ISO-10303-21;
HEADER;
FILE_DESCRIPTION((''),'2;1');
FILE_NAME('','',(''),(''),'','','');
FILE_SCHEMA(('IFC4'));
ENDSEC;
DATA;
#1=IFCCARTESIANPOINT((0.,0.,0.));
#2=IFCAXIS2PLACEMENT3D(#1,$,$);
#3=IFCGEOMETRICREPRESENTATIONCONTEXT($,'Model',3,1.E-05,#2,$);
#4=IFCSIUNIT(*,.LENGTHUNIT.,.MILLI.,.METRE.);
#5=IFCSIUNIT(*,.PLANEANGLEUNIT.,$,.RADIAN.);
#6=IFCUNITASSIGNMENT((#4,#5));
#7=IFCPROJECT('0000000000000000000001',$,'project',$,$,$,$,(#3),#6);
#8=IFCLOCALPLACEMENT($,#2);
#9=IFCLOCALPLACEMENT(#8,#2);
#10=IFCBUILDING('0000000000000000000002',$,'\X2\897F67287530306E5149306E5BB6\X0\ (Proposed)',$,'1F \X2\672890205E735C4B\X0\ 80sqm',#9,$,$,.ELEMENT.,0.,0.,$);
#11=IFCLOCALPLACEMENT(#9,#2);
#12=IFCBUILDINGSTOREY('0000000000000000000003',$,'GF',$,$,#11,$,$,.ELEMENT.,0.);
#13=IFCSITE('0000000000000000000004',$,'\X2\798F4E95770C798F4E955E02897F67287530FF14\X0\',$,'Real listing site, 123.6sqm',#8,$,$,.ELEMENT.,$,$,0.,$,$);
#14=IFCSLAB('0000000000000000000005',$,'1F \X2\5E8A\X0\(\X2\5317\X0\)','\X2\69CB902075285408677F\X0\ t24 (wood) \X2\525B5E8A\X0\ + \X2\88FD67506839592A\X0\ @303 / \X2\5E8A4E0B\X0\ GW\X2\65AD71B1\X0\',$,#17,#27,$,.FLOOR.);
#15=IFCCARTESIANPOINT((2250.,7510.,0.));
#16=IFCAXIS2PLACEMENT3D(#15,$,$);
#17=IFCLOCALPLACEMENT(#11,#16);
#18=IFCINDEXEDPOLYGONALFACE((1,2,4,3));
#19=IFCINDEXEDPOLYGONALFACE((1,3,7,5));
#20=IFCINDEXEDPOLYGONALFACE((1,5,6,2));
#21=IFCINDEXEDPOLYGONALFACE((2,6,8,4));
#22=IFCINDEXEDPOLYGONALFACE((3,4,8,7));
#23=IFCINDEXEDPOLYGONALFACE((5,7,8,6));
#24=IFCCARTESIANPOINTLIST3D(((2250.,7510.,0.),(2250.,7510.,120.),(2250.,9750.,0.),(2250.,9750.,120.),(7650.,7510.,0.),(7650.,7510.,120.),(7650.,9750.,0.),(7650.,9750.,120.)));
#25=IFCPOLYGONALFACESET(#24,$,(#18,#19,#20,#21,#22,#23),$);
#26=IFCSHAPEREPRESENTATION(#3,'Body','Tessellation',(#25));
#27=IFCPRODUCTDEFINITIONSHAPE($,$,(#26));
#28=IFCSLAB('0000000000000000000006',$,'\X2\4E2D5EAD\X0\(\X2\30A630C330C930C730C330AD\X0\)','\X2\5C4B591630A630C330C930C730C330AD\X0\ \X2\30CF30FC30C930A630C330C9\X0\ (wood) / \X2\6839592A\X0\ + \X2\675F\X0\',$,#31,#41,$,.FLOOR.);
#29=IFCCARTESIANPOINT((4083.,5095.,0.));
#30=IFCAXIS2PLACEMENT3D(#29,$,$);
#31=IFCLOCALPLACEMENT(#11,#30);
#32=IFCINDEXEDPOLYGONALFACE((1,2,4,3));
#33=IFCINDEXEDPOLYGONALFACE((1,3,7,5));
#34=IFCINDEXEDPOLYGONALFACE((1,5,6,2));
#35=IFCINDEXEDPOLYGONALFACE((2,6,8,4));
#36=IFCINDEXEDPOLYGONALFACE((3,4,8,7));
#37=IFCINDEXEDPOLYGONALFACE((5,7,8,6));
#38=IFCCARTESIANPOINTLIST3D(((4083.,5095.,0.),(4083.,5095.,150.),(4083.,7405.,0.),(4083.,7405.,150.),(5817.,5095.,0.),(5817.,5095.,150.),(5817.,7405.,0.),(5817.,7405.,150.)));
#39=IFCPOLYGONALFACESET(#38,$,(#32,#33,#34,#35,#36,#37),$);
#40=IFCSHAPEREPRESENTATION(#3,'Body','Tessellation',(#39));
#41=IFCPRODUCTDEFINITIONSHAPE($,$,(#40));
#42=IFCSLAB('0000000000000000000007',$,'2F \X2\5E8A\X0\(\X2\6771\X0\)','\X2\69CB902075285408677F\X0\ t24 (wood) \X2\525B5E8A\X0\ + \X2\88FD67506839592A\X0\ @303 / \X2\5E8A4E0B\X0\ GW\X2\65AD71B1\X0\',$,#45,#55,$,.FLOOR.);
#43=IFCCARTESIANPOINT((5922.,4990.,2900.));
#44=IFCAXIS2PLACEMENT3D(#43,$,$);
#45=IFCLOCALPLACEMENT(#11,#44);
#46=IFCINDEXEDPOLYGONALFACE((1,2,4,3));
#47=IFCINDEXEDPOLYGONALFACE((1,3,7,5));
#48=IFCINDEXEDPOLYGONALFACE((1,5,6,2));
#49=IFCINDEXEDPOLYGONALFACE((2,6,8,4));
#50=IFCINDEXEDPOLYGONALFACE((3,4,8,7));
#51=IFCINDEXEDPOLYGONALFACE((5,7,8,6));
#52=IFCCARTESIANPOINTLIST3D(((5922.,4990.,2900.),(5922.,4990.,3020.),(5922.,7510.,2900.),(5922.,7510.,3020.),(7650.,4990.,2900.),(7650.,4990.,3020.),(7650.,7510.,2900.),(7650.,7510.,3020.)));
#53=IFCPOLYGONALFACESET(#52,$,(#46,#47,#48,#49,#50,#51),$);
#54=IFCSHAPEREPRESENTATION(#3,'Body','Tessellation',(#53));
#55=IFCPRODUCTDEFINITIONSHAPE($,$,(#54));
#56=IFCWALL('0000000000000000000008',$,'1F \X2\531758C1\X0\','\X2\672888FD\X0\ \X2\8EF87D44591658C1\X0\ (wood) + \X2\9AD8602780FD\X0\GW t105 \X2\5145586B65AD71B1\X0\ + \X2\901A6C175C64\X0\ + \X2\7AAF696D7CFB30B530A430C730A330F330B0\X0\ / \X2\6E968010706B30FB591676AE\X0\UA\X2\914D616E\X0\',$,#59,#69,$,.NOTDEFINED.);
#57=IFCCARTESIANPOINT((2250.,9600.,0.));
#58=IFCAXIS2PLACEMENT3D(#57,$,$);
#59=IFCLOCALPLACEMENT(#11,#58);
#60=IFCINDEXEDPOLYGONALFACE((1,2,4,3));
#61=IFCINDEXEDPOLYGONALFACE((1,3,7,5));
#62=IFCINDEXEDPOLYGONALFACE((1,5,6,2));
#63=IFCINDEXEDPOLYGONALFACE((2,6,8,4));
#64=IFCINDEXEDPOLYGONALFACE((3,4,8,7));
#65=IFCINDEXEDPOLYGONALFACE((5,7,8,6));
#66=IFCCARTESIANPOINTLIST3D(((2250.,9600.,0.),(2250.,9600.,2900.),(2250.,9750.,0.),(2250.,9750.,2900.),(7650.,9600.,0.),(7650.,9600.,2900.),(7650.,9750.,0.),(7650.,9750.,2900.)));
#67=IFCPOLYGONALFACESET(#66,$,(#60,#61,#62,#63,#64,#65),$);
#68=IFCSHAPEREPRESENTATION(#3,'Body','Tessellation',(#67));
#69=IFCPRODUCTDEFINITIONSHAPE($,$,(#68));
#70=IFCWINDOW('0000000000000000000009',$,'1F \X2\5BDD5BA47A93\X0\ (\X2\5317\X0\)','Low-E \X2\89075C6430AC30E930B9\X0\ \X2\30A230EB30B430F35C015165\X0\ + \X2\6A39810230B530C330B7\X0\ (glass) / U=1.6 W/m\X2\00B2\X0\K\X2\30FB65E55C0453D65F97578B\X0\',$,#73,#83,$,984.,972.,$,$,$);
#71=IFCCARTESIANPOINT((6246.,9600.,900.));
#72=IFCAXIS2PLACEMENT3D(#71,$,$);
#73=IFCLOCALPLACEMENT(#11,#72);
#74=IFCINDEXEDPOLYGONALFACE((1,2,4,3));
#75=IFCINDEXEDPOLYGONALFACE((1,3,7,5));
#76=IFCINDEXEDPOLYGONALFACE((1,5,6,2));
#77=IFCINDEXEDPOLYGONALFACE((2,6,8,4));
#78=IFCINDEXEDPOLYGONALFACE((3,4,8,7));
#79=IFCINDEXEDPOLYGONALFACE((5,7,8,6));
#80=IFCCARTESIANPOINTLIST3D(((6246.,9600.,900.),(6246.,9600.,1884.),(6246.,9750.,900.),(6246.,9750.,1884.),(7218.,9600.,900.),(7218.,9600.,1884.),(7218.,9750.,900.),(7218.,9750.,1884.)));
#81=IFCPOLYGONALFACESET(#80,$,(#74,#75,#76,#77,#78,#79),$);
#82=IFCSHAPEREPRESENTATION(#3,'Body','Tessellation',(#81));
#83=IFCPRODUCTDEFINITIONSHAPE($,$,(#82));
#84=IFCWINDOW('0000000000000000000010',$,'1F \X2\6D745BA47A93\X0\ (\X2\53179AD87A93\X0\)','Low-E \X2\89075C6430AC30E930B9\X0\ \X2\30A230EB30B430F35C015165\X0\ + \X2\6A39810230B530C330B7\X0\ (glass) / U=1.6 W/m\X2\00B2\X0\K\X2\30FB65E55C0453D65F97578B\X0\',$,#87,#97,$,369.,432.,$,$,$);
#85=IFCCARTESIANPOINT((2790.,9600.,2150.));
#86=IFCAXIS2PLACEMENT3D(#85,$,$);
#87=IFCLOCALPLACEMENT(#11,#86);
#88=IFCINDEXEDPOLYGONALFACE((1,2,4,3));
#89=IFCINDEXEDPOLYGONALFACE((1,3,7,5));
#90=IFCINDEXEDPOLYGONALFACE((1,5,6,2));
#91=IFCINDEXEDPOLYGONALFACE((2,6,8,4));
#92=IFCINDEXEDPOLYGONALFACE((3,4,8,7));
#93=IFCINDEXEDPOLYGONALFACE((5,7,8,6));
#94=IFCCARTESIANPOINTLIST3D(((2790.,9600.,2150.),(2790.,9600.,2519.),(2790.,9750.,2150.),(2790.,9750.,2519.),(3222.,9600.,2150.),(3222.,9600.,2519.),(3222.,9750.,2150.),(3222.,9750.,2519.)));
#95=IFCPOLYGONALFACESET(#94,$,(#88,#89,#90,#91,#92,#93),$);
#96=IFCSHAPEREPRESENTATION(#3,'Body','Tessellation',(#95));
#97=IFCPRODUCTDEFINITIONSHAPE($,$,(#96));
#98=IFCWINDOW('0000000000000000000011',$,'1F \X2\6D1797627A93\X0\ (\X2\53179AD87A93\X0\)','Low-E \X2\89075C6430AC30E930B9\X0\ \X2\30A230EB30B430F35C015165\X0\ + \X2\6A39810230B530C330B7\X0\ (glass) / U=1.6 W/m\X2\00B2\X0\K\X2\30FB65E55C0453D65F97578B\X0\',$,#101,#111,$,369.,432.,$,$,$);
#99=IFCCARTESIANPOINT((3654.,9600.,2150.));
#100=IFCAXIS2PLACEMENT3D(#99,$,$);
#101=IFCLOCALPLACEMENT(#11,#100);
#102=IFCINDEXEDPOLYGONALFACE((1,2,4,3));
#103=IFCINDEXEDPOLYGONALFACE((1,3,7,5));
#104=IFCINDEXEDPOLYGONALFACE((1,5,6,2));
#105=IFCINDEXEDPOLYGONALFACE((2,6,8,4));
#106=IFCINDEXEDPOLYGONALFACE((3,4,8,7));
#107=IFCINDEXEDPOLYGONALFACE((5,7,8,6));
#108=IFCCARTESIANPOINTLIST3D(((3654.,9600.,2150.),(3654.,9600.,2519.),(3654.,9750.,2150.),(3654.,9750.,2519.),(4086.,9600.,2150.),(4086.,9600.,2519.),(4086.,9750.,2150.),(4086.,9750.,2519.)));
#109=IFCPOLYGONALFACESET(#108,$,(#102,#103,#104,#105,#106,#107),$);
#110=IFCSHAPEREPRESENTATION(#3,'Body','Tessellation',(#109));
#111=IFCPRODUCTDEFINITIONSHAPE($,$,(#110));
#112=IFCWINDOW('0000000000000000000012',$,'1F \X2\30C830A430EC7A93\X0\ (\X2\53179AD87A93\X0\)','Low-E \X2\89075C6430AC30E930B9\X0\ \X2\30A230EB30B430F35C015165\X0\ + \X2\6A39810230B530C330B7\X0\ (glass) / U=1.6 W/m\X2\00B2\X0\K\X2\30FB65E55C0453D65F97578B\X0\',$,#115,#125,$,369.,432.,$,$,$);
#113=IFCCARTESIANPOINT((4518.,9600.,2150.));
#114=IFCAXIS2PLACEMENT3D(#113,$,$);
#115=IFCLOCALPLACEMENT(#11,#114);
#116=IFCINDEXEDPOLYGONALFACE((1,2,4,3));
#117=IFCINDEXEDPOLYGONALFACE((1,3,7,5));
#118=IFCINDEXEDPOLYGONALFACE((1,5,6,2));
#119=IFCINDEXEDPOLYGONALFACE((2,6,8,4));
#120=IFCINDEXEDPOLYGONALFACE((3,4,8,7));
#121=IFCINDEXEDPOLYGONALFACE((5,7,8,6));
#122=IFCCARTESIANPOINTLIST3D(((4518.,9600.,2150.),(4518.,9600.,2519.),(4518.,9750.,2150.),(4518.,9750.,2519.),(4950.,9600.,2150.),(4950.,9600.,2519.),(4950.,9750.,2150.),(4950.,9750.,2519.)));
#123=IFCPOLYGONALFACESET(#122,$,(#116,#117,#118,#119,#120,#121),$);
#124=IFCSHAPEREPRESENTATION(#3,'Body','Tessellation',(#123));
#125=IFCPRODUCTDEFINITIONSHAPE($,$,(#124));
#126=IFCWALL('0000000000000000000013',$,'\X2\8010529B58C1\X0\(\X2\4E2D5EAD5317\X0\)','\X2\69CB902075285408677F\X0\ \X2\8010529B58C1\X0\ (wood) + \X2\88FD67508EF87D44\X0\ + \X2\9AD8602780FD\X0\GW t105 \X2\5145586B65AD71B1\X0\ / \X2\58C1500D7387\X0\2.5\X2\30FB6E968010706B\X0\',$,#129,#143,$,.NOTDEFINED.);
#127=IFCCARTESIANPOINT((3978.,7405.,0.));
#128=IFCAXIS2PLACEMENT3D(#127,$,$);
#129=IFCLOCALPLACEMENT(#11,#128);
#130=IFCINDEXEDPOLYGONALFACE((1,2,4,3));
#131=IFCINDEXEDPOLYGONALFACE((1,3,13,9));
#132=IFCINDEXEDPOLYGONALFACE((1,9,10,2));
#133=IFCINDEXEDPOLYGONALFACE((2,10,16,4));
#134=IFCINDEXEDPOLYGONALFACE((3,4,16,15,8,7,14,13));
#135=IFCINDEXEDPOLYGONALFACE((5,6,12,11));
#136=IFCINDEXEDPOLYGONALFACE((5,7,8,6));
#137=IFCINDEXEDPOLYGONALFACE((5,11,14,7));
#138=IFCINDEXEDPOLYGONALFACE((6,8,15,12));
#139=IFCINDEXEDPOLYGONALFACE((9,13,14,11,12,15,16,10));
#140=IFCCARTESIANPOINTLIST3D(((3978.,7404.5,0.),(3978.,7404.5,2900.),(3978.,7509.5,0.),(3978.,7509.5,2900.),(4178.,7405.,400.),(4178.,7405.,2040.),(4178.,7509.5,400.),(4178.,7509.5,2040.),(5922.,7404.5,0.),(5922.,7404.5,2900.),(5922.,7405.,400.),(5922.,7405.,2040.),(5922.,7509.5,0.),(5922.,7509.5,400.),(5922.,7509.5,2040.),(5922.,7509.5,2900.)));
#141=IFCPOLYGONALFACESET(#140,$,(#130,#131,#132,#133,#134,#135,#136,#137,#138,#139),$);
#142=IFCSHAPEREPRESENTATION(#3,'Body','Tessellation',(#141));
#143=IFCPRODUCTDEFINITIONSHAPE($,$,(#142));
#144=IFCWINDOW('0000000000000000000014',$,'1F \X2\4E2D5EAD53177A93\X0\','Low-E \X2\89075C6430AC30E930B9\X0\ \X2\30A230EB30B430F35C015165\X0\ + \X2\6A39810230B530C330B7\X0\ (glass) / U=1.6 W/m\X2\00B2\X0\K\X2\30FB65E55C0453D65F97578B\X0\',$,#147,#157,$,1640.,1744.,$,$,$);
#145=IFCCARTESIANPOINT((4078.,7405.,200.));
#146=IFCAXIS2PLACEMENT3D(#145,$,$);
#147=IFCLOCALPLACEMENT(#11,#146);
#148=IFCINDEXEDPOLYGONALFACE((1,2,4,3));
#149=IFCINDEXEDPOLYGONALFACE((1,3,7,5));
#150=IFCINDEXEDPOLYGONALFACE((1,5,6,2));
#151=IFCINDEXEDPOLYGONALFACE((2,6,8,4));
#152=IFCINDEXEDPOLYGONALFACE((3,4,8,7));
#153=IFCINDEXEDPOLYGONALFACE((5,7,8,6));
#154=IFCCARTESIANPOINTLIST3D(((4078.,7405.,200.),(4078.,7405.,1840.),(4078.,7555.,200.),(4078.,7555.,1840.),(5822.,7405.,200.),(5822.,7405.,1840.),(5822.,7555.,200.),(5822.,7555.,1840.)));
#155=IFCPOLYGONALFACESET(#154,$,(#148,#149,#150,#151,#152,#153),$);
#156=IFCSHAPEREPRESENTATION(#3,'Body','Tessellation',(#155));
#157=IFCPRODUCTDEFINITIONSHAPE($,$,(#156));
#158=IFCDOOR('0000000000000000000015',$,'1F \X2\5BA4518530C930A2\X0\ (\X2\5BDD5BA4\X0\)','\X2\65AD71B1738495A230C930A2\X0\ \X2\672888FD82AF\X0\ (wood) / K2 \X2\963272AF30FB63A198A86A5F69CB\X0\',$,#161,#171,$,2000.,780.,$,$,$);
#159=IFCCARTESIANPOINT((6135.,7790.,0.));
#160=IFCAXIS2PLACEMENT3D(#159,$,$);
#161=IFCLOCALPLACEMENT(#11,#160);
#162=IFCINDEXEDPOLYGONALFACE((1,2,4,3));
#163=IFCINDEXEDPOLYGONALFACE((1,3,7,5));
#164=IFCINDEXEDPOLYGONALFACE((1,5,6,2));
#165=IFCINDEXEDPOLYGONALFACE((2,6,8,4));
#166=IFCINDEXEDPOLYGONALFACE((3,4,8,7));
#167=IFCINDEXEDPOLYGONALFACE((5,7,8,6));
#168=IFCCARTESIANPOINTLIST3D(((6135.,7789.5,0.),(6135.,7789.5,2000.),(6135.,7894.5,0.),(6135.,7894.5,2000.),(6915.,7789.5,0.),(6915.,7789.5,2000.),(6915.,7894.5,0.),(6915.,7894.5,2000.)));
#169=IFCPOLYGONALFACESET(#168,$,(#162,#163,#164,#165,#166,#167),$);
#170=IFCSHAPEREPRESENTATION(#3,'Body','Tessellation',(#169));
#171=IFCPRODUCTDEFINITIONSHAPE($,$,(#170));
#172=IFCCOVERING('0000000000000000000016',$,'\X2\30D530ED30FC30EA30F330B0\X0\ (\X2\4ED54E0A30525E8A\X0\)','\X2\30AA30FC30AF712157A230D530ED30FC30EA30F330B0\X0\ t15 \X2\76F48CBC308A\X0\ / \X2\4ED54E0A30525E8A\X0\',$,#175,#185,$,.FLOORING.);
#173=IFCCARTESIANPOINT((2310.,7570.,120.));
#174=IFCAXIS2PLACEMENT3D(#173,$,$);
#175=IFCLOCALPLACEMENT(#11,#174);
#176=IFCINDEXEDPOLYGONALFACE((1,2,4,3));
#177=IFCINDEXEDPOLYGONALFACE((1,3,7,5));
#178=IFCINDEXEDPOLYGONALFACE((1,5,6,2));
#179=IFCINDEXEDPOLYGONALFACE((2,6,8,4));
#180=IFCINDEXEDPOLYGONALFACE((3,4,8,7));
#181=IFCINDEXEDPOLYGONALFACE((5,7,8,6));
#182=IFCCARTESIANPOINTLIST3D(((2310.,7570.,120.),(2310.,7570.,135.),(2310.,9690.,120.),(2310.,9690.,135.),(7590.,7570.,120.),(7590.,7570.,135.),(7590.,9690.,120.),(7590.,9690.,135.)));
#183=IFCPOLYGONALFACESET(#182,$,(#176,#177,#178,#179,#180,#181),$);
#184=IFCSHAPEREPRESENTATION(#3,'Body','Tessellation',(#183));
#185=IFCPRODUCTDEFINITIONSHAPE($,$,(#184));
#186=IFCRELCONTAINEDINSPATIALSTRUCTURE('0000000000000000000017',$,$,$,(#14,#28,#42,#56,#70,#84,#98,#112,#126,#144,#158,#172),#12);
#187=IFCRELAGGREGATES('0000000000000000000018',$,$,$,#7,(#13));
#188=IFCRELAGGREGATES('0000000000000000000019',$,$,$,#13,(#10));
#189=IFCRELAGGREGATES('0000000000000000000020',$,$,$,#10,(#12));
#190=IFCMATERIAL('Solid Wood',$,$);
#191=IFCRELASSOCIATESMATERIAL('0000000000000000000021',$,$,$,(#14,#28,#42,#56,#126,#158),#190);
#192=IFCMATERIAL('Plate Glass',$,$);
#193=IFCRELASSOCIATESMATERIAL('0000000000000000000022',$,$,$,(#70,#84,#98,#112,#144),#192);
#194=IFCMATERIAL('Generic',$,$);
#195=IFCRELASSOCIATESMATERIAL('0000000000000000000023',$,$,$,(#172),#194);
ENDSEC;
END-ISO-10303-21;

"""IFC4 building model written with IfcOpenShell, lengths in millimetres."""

from ifc_helpers import new_model, si_unit, frame, frame_2d, origin, place, context, project, spatial, rectangle, extrude, material, element, fill, save


model = new_model("IFC4")

# Units and contexts
model_context = context("Model", 3, precision=1e-05, world=origin())
ifc_project = project(units=[si_unit("LENGTHUNIT", "METRE", prefix="MILLI"), si_unit("PLANEANGLEUNIT", "RADIAN")], contexts=[model_context])

# Site, building, storey
site_placement = place(None, origin())
site = spatial("IfcSite", under=ifc_project, at=site_placement, Name="福井県福井市西木田４", ObjectType="Real listing site, 123.6sqm", CompositionType="ELEMENT", RefElevation=0.0)
building_placement = place(site_placement, origin())
building = spatial("IfcBuilding", under=site, at=building_placement, Name="西木田の光の家 (Proposed)", ObjectType="1F 木造平屋 80sqm", CompositionType="ELEMENT", ElevationOfRefHeight=0.0, ElevationOfTerrain=0.0)
storey_placement = place(building_placement, origin())
storey = spatial("IfcBuildingStorey", under=building, at=storey_placement, Name="GF", CompositionType="ELEMENT", Elevation=0.0)

# Slabs
ifc_material_1 = material(Name="Solid Wood")
slab_1_placement = place(storey_placement, frame((2250.0, 7510.0, 0.0)))
element("IfcSlab", 1, at=slab_1_placement, inside=storey, material=ifc_material_1, Name="1F 床(北)", Description="構造用合板 t24 (wood) 剛床 + 製材根太 @303 / 床下 GW断熱", PredefinedType="FLOOR", context=model_context, shape_type="SweptSolid", body=[
    extrude(rectangle(XDim=5400.0, YDim=2240.0, at=frame_2d((2700.0, 1120.0))), frame((2250.0, 7510.0, 0.0)), (0.0, 0.0, 1.0), 120.0),
])
slab_2_placement = place(storey_placement, frame((4083.0, 5095.0, 0.0)))
element("IfcSlab", 2, at=slab_2_placement, inside=storey, material=ifc_material_1, Name="中庭(ウッドデッキ)", Description="屋外ウッドデッキ ハードウッド (wood) / 根太 + 束", PredefinedType="FLOOR", context=model_context, shape_type="SweptSolid", body=[
    extrude(rectangle(XDim=1734.0, YDim=2310.0, at=frame_2d((867.0, 1155.0))), frame((4083.0, 5095.0, 0.0)), (0.0, 0.0, 1.0), 150.0),
])
slab_3_placement = place(storey_placement, frame((5922.0, 4990.0, 2900.0)))
element("IfcSlab", 3, at=slab_3_placement, inside=storey, material=ifc_material_1, Name="2F 床(東)", Description="構造用合板 t24 (wood) 剛床 + 製材根太 @303 / 床下 GW断熱", PredefinedType="FLOOR", context=model_context, shape_type="SweptSolid", body=[
    extrude(rectangle(XDim=1728.0, YDim=2520.0, at=frame_2d((864.0, 1260.0))), frame((5922.0, 4990.0, 2900.0)), (0.0, 0.0, 1.0), 120.0),
])

# Wall, openings, windows
wall_1_placement = place(storey_placement, frame((2250.0, 9600.0, 0.0)))
wall_1 = element("IfcWall", 4, at=wall_1_placement, inside=storey, material=ifc_material_1, Name="1F 北壁", Description="木製 軸組外壁 (wood) + 高性能GW t105 充填断熱 + 通気層 + 窯業系サイディング / 準耐火・外皮UA配慮", PredefinedType="NOTDEFINED", context=model_context, shape_type="SweptSolid", body=[
    extrude(rectangle(XDim=5400.0, YDim=150.0, at=frame_2d((2700.0, 75.0))), frame((2250.0, 9600.0, 0.0)), (0.0, 0.0, 1.0), 2900.0),
])
opening_1_placement = place(storey_placement, frame((6246.0, 9600.0, 900.0)))
opening_1 = element("IfcOpeningElement", 5, at=opening_1_placement, cuts=wall_1, PredefinedType="NOTDEFINED", context=model_context, shape_type="SweptSolid", body=[
    extrude(rectangle(XDim=972.0, YDim=150.0, at=frame_2d((486.0, 75.0))), frame((6246.0, 9600.0, 900.0)), (0.0, 0.0, 1.0), 984.0),
])
opening_2_placement = place(storey_placement, frame((2790.0, 9600.0, 2150.0)))
opening_2 = element("IfcOpeningElement", 6, at=opening_2_placement, cuts=wall_1, PredefinedType="NOTDEFINED", context=model_context, shape_type="SweptSolid", body=[
    extrude(rectangle(XDim=432.0, YDim=150.0, at=frame_2d((216.0, 75.0))), frame((2790.0, 9600.0, 2150.0)), (0.0, 0.0, 1.0), 369.0),
])
opening_3_placement = place(storey_placement, frame((3654.0, 9600.0, 2150.0)))
opening_3 = element("IfcOpeningElement", 7, at=opening_3_placement, cuts=wall_1, PredefinedType="NOTDEFINED", context=model_context, shape_type="SweptSolid", body=[
    extrude(rectangle(XDim=432.0, YDim=150.0, at=frame_2d((216.0, 75.0))), frame((3654.0, 9600.0, 2150.0)), (0.0, 0.0, 1.0), 369.0),
])
opening_4_placement = place(storey_placement, frame((4518.0, 9600.0, 2150.0)))
opening_4 = element("IfcOpeningElement", 8, at=opening_4_placement, cuts=wall_1, PredefinedType="NOTDEFINED", context=model_context, shape_type="SweptSolid", body=[
    extrude(rectangle(XDim=432.0, YDim=150.0, at=frame_2d((216.0, 75.0))), frame((4518.0, 9600.0, 2150.0)), (0.0, 0.0, 1.0), 369.0),
])
ifc_material_2 = material(Name="Plate Glass")
window_1_placement = place(storey_placement, frame((6246.0, 9600.0, 900.0)))
window_1 = element("IfcWindow", 9, at=window_1_placement, inside=storey, material=ifc_material_2, Name="1F 寝室窓 (北)", Description="Low-E 複層ガラス アルゴン封入 + 樹脂サッシ (glass) / U=1.6 W/m²K・日射取得型", OverallHeight=984.0, OverallWidth=972.0, context=model_context, shape_type="SweptSolid", body=[
    extrude(rectangle(XDim=972.0, YDim=150.0, at=frame_2d((486.0, 75.0))), frame((6246.0, 9600.0, 900.0)), (0.0, 0.0, 1.0), 984.0),
])
fill(opening_1, window_1)
window_2_placement = place(storey_placement, frame((2790.0, 9600.0, 2150.0)))
window_2 = element("IfcWindow", 10, at=window_2_placement, inside=storey, material=ifc_material_2, Name="1F 浴室窓 (北高窓)", Description="Low-E 複層ガラス アルゴン封入 + 樹脂サッシ (glass) / U=1.6 W/m²K・日射取得型", OverallHeight=369.0, OverallWidth=432.0, context=model_context, shape_type="SweptSolid", body=[
    extrude(rectangle(XDim=432.0, YDim=150.0, at=frame_2d((216.0, 75.0))), frame((2790.0, 9600.0, 2150.0)), (0.0, 0.0, 1.0), 369.0),
])
fill(opening_2, window_2)
window_3_placement = place(storey_placement, frame((3654.0, 9600.0, 2150.0)))
window_3 = element("IfcWindow", 11, at=window_3_placement, inside=storey, material=ifc_material_2, Name="1F 洗面窓 (北高窓)", Description="Low-E 複層ガラス アルゴン封入 + 樹脂サッシ (glass) / U=1.6 W/m²K・日射取得型", OverallHeight=369.0, OverallWidth=432.0, context=model_context, shape_type="SweptSolid", body=[
    extrude(rectangle(XDim=432.0, YDim=150.0, at=frame_2d((216.0, 75.0))), frame((3654.0, 9600.0, 2150.0)), (0.0, 0.0, 1.0), 369.0),
])
fill(opening_3, window_3)
window_4_placement = place(storey_placement, frame((4518.0, 9600.0, 2150.0)))
window_4 = element("IfcWindow", 12, at=window_4_placement, inside=storey, material=ifc_material_2, Name="1F トイレ窓 (北高窓)", Description="Low-E 複層ガラス アルゴン封入 + 樹脂サッシ (glass) / U=1.6 W/m²K・日射取得型", OverallHeight=369.0, OverallWidth=432.0, context=model_context, shape_type="SweptSolid", body=[
    extrude(rectangle(XDim=432.0, YDim=150.0, at=frame_2d((216.0, 75.0))), frame((4518.0, 9600.0, 2150.0)), (0.0, 0.0, 1.0), 369.0),
])
fill(opening_4, window_4)

# Wall, opening, window
wall_2_placement = place(storey_placement, frame((3978.0, 7405.0, 0.0)))
wall_2 = element("IfcWall", 13, at=wall_2_placement, inside=storey, material=ifc_material_1, Name="耐力壁(中庭北)", Description="構造用合板 耐力壁 (wood) + 製材軸組 + 高性能GW t105 充填断熱 / 壁倍率2.5・準耐火", PredefinedType="NOTDEFINED", context=model_context, shape_type="SweptSolid", body=[
    extrude(rectangle(XDim=1944.0, YDim=105.0, at=frame_2d((972.0, 52.0))), frame((3978.0, 7405.0, 0.0)), (0.0, 0.0, 1.0), 2900.0),
])
opening_5_placement = place(storey_placement, frame((4078.0, 7405.0, 200.0)))
opening_5 = element("IfcOpeningElement", 14, at=opening_5_placement, cuts=wall_2, PredefinedType="NOTDEFINED", context=model_context, shape_type="SweptSolid", body=[
    extrude(rectangle(XDim=1744.0, YDim=150.0, at=frame_2d((872.0, 75.0))), frame((4078.0, 7405.0, 200.0)), (0.0, 0.0, 1.0), 1640.0),
])
window_5_placement = place(storey_placement, frame((4078.0, 7405.0, 200.0)))
window_5 = element("IfcWindow", 15, at=window_5_placement, inside=storey, material=ifc_material_2, Name="1F 中庭北窓", Description="Low-E 複層ガラス アルゴン封入 + 樹脂サッシ (glass) / U=1.6 W/m²K・日射取得型", OverallHeight=1640.0, OverallWidth=1744.0, context=model_context, shape_type="SweptSolid", body=[
    extrude(rectangle(XDim=1744.0, YDim=150.0, at=frame_2d((872.0, 75.0))), frame((4078.0, 7405.0, 200.0)), (0.0, 0.0, 1.0), 1640.0),
])
fill(opening_5, window_5)

# Door
door_1_placement = place(storey_placement, frame((6135.0, 7790.0, 0.0)))
element("IfcDoor", 16, at=door_1_placement, inside=storey, material=ifc_material_1, Name="1F 室内ドア (寝室)", Description="断熱玄関ドア 木製芯 (wood) / K2 防犯・採風機構", OverallHeight=2000.0, OverallWidth=780.0, context=model_context, shape_type="SweptSolid", body=[
    extrude(rectangle(XDim=780.0, YDim=105.0, at=frame_2d((390.0, 52.0))), frame((6135.0, 7790.0, 0.0)), (0.0, 0.0, 1.0), 2000.0),
])

# Covering
ifc_material_3 = material(Name="Generic")
covering_1_placement = place(storey_placement, frame((2310.0, 7570.0, 120.0)))
element("IfcCovering", 17, at=covering_1_placement, inside=storey, material=ifc_material_3, Name="フローリング (仕上げ床)", Description="オーク無垢フローリング t15 直貼り / 仕上げ床", PredefinedType="FLOORING", context=model_context, shape_type="SweptSolid", body=[
    extrude(rectangle(XDim=5280.0, YDim=2120.0, at=frame_2d((2640.0, 1060.0))), frame((2310.0, 7570.0, 120.0)), (0.0, 0.0, 1.0), 15.0),
])

save(model, "model.ifc")
